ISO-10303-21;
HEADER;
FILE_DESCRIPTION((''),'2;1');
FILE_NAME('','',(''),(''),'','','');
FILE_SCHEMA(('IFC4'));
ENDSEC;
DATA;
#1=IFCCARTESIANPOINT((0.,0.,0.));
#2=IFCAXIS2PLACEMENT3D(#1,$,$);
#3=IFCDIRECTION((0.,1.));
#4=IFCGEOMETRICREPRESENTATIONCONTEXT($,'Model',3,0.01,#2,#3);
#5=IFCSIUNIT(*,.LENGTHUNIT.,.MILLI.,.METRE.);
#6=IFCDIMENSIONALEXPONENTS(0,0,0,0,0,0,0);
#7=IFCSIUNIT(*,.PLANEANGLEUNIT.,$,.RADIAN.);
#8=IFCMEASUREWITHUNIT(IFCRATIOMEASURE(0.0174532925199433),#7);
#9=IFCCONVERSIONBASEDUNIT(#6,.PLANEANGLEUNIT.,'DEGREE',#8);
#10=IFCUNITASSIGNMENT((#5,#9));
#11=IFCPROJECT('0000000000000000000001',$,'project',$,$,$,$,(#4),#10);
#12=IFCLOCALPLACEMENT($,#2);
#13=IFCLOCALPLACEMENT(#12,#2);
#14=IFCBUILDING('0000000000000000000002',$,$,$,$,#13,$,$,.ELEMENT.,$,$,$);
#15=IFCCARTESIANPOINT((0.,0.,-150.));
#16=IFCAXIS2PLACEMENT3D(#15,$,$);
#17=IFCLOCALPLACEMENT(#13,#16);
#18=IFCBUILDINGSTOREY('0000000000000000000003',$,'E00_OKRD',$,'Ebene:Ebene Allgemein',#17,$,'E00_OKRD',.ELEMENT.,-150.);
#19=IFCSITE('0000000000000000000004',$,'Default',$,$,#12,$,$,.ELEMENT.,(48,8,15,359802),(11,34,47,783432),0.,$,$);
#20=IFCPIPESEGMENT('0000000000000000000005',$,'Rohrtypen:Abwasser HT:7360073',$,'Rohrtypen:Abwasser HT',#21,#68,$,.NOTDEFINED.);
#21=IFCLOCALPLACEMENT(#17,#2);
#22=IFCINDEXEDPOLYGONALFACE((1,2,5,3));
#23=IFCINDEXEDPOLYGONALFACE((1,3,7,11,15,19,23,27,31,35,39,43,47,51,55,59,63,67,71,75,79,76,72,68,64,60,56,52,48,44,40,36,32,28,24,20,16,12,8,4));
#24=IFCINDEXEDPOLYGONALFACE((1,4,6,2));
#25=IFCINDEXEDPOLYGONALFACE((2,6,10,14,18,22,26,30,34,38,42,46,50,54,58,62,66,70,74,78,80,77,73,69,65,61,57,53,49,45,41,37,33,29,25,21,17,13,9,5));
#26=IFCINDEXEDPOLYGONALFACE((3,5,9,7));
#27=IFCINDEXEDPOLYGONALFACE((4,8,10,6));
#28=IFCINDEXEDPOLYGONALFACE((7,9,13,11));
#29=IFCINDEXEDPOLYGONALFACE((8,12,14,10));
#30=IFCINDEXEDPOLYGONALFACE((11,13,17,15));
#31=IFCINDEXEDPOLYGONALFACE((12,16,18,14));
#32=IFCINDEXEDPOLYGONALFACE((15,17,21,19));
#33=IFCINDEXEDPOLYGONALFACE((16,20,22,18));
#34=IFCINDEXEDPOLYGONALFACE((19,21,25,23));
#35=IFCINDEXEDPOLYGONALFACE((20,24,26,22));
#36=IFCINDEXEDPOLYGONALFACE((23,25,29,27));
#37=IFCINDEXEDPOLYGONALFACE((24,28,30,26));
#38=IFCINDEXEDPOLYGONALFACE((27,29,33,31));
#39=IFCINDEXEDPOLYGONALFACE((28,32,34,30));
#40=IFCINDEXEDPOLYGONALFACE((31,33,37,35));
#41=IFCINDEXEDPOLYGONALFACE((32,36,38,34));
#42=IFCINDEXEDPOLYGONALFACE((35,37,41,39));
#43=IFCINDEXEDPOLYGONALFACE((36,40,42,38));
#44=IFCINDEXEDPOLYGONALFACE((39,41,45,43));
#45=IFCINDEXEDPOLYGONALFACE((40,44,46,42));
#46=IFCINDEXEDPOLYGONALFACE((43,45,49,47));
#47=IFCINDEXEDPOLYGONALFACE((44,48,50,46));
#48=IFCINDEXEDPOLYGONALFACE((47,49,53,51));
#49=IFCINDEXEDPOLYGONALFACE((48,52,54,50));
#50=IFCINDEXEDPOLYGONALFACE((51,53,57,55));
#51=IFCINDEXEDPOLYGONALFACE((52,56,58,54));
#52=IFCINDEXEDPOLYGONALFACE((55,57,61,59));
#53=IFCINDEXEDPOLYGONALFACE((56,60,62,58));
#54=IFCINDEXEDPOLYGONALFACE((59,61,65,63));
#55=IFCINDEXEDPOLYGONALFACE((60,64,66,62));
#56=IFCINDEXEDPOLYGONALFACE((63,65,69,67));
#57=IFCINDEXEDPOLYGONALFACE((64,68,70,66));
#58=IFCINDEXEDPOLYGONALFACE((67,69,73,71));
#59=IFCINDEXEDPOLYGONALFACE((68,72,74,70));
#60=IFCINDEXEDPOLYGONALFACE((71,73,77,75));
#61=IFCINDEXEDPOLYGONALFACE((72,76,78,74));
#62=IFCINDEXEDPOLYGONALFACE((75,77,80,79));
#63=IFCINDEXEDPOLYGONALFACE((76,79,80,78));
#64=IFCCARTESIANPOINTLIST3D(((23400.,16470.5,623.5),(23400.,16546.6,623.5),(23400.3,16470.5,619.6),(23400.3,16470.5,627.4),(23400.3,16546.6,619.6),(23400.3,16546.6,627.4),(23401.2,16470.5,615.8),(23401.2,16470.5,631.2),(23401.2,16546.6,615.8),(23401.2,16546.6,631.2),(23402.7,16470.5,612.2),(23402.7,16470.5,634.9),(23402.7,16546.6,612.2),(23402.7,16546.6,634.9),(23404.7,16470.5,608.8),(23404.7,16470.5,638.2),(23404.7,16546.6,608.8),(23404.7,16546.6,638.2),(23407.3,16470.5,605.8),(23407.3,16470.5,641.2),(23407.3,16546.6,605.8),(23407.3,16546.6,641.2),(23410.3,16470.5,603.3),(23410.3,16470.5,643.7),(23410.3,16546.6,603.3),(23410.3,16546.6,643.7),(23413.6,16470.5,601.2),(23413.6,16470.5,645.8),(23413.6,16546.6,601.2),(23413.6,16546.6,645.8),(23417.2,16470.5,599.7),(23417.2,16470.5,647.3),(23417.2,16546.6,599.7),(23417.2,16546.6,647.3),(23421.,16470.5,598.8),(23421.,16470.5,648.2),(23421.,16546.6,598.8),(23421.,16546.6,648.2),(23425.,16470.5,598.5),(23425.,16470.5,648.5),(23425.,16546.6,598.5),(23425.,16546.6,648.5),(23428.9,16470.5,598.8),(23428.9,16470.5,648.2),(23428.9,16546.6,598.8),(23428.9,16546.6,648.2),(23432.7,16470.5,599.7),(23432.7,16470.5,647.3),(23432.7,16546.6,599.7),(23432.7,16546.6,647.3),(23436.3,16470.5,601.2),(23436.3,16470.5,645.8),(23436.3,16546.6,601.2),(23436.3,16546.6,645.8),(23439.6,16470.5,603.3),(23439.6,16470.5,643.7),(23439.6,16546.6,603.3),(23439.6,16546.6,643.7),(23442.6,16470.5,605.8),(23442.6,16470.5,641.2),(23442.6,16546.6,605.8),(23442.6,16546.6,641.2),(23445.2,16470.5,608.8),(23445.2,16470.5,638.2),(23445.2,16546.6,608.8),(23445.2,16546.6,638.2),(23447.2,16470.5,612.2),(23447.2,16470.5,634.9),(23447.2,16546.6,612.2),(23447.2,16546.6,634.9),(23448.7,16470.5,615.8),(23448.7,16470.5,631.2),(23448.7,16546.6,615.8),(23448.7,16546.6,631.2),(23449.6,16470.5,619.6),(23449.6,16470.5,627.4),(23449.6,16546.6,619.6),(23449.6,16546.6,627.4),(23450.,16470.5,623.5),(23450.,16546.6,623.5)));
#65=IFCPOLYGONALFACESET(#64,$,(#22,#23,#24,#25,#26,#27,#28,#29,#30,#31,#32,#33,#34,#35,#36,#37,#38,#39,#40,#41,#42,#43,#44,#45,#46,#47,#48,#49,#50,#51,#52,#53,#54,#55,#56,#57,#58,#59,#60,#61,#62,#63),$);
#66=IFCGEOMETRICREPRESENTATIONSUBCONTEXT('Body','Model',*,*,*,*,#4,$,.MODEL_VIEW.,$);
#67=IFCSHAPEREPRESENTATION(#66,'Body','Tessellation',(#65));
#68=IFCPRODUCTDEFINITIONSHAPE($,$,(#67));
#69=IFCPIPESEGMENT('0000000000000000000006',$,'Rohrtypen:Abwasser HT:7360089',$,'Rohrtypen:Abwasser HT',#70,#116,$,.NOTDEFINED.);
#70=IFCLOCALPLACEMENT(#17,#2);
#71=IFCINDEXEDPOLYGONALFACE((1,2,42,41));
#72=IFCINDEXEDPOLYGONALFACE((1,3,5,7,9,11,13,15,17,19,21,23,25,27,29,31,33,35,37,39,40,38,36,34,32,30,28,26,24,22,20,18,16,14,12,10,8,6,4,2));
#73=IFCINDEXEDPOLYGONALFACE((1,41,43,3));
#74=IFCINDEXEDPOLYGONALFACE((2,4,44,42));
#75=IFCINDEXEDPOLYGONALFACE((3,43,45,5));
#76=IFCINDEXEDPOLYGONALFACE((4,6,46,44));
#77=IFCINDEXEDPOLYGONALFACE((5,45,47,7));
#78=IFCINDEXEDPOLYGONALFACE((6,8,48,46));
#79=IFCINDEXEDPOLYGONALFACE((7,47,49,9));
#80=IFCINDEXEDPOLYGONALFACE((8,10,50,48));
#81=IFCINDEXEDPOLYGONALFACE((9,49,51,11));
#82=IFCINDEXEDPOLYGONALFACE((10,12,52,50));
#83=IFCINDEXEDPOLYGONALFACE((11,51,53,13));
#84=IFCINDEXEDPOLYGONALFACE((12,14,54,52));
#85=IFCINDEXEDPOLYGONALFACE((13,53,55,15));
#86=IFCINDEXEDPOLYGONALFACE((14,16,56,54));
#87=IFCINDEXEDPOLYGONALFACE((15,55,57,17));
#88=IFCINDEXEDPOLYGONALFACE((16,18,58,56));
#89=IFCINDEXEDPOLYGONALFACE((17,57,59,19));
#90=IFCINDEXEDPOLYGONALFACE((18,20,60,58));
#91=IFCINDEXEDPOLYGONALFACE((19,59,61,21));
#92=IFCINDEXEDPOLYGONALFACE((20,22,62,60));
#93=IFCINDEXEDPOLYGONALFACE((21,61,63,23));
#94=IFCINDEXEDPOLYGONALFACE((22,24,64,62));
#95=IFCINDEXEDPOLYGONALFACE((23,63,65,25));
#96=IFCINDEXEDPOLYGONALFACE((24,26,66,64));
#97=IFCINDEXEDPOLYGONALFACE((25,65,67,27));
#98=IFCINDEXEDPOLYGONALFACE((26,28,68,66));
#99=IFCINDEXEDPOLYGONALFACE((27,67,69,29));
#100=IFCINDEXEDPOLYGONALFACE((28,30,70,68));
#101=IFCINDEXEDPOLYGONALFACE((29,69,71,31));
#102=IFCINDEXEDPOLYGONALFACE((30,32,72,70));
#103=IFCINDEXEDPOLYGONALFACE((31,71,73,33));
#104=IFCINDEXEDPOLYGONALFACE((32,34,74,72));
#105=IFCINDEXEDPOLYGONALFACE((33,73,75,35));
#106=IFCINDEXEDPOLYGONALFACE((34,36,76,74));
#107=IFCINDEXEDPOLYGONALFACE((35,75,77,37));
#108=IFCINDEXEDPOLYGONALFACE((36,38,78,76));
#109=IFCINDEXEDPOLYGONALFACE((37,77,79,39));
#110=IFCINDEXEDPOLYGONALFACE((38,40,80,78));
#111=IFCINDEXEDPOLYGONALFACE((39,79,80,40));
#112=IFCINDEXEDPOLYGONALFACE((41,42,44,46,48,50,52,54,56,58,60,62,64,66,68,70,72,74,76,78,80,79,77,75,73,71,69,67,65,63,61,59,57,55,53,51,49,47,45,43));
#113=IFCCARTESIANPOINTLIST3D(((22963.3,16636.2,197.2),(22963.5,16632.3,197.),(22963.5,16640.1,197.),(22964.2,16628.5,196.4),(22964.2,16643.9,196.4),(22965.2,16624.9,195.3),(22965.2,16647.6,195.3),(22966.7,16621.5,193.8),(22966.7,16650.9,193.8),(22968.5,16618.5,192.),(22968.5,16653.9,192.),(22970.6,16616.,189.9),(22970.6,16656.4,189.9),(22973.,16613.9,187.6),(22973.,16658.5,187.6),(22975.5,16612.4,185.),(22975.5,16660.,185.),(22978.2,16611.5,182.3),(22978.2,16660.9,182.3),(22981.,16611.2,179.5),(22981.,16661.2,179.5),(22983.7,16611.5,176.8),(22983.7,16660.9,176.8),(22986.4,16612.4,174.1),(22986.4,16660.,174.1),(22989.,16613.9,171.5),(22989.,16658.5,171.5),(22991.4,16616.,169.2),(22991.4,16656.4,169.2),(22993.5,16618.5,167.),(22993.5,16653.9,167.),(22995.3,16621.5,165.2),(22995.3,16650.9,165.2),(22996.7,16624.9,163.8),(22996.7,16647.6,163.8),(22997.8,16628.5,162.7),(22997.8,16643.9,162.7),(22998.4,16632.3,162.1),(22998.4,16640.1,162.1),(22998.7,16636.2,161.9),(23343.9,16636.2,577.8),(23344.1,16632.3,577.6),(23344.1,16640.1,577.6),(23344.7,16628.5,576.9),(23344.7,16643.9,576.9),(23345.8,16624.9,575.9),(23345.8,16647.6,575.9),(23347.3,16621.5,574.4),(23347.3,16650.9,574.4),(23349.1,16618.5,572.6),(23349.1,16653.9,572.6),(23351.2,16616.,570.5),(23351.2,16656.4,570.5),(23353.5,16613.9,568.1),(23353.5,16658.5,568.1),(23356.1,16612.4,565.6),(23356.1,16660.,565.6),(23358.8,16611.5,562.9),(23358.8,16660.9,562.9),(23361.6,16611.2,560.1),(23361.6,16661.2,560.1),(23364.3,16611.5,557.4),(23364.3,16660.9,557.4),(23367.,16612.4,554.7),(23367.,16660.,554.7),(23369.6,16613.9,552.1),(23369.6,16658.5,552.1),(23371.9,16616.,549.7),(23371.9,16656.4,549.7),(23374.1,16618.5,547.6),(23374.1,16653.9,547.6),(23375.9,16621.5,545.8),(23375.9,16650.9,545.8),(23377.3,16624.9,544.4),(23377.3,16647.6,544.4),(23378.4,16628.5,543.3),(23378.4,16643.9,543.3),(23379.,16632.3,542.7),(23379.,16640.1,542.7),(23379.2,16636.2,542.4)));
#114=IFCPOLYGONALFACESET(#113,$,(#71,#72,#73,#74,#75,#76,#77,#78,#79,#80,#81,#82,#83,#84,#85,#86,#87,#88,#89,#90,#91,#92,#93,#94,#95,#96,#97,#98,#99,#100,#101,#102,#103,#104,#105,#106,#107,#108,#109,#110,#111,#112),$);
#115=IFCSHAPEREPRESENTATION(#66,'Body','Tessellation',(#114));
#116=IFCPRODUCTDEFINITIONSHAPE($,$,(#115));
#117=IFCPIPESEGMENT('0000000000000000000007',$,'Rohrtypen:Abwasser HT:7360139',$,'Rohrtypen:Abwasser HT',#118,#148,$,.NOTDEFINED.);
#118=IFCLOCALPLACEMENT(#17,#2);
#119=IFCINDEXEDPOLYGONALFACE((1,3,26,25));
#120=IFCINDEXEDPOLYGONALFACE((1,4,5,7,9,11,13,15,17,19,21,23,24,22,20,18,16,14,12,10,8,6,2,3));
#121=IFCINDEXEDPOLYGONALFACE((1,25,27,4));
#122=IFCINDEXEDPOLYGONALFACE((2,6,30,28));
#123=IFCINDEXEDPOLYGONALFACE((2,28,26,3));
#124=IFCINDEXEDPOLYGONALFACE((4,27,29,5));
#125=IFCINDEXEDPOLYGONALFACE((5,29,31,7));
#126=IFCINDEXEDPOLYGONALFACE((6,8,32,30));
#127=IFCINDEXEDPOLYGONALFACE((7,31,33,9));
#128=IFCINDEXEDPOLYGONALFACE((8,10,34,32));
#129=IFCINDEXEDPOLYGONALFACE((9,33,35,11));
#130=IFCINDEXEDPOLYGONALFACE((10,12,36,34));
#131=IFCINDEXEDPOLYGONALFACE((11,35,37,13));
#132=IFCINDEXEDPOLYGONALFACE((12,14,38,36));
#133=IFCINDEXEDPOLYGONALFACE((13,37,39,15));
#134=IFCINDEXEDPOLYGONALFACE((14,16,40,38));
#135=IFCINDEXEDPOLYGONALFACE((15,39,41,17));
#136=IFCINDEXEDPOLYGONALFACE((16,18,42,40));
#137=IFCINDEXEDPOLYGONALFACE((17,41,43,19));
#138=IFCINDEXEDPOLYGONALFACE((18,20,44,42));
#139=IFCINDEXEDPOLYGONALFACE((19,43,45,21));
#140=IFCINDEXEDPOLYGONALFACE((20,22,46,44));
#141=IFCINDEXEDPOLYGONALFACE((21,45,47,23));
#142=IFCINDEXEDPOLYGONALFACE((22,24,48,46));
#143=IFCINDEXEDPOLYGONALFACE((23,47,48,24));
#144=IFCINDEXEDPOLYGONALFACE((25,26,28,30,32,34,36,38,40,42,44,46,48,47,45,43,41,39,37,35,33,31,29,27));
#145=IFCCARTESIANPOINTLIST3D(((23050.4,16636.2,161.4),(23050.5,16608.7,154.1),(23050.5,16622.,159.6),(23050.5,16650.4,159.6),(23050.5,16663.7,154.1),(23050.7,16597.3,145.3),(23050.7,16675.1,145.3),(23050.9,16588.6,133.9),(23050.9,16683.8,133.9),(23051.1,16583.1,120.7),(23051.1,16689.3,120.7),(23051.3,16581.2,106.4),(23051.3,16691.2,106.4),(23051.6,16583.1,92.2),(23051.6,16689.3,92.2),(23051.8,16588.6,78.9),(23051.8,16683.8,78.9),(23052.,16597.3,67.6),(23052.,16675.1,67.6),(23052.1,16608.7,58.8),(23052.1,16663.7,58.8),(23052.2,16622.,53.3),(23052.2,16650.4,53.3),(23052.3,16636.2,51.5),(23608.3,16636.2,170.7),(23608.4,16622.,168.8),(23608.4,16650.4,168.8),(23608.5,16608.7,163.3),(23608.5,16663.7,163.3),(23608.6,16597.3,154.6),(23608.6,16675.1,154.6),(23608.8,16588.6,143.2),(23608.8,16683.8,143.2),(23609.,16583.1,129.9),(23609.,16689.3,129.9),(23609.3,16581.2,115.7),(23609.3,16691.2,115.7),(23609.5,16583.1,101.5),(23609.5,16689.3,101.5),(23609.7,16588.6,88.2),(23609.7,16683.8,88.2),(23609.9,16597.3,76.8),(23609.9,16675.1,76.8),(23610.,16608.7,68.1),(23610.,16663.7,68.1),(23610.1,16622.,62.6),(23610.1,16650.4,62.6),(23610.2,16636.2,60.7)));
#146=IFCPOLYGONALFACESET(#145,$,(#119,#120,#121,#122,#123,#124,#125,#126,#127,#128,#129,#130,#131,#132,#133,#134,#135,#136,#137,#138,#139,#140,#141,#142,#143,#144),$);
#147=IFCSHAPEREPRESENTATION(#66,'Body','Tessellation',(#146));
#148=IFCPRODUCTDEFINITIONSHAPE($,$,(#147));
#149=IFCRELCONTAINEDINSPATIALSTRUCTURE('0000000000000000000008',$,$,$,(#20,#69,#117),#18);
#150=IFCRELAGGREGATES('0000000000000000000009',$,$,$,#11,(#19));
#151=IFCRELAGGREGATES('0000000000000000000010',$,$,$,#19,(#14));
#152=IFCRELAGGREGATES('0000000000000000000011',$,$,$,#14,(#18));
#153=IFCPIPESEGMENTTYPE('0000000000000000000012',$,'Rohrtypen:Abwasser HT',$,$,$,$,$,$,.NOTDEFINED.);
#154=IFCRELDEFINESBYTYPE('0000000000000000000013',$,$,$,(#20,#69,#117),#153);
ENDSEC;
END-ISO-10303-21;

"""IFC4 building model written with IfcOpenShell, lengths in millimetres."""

from ifc_helpers import new_model, entity, si_unit, converted_unit, direction, frame, origin, place, context, subcontext, project, spatial, indexed_curve, outline, extrude, type_object, element, save


model = new_model("IFC4")

# Units and contexts
model_context = context("Model", 3, precision=0.01, world=origin(), true_north=direction((0.0, 1.0)))
body_context = subcontext(model_context, "Body", "Model", "MODEL_VIEW")
ifc_project = project(units=[si_unit("LENGTHUNIT", "METRE", prefix="MILLI"), converted_unit("PLANEANGLEUNIT", "DEGREE", entity("IfcRatioMeasure", 0.0174532925199433), si_unit("PLANEANGLEUNIT", "RADIAN"), dimensions=[0, 0, 0, 0, 0, 0, 0])], contexts=[model_context])

# Site, building, storey
site_placement = place(None, origin())
site = spatial("IfcSite", under=ifc_project, at=site_placement, Name="Default", CompositionType="ELEMENT", RefLatitude=(48, 8, 15, 359802), RefLongitude=(11, 34, 47, 783432), RefElevation=0.0)
building_placement = place(site_placement, origin())
building = spatial("IfcBuilding", under=site, at=building_placement, CompositionType="ELEMENT")
storey_placement = place(building_placement, frame((0.0, 0.0, -150.0)))
storey = spatial("IfcBuildingStorey", under=building, at=storey_placement, Name="E00_OKRD", ObjectType="Ebene:Ebene Allgemein", LongName="E00_OKRD", CompositionType="ELEMENT", Elevation=-150.0)

# Pipe segments
pipe_segment_type_1 = type_object("IfcPipeSegmentType", Name="Rohrtypen:Abwasser HT", PredefinedType="NOTDEFINED")
pipe_segment_1_placement = place(storey_placement, origin())
element("IfcPipeSegment", 1, at=pipe_segment_1_placement, inside=storey, type_object=pipe_segment_type_1, Name="Rohrtypen:Abwasser HT:7360073", ObjectType="Rohrtypen:Abwasser HT", PredefinedType="NOTDEFINED", context=body_context, shape_type="SweptSolid", body=[
    extrude(outline(indexed_curve([(25.0, 0.0), (24.7, 3.9), (23.8, 7.7), (22.3, 11.3), (20.2, 14.7), (17.7, 17.7), (14.7, 20.2), (11.3, 22.3), (7.7, 23.8), (3.9, 24.7), (0.0, 25.0), (-3.9, 24.7), (-7.7, 23.8), (-11.3, 22.3), (-14.7, 20.2), (-17.7, 17.7), (-20.2, 14.7), (-22.3, 11.3), (-23.8, 7.7), (-24.7, 3.9), (-25.0, 0.0), (-24.7, -3.9), (-23.8, -7.7), (-22.3, -11.3), (-20.2, -14.7), (-17.7, -17.7), (-14.7, -20.2), (-11.3, -22.3), (-7.7, -23.8), (-3.9, -24.7), (0.0, -25.0), (3.9, -24.7), (7.7, -23.8), (11.3, -22.3), (14.7, -20.2), (17.7, -17.7), (20.2, -14.7), (22.3, -11.3), (23.8, -7.7), (24.7, -3.9), (25.0, 0.0)], self_intersect=False)), frame((23425.0, 16470.5, 623.5), z_axis=(0.0, 1.0, 0.0), x_axis=(1.0, 0.0, 0.0)), (0.0, 0.0, 1.0), 76.0),
])
pipe_segment_2_placement = place(storey_placement, origin())
element("IfcPipeSegment", 2, at=pipe_segment_2_placement, inside=storey, type_object=pipe_segment_type_1, Name="Rohrtypen:Abwasser HT:7360089", ObjectType="Rohrtypen:Abwasser HT", PredefinedType="NOTDEFINED", context=body_context, shape_type="SweptSolid", body=[
    extrude(outline(indexed_curve([(25.0, 0.0), (24.7, 3.9), (23.8, 7.7), (22.3, 11.3), (20.2, 14.7), (17.7, 17.7), (14.7, 20.2), (11.3, 22.3), (7.7, 23.8), (3.9, 24.7), (0.0, 25.0), (-3.9, 24.7), (-7.7, 23.8), (-11.3, 22.3), (-14.7, 20.2), (-17.7, 17.7), (-20.2, 14.7), (-22.3, 11.3), (-23.8, 7.7), (-24.7, 3.9), (-25.0, 0.0), (-24.7, -3.9), (-23.8, -7.7), (-22.3, -11.3), (-20.2, -14.7), (-17.7, -17.7), (-14.7, -20.2), (-11.3, -22.3), (-7.7, -23.8), (-3.9, -24.7), (0.0, -25.0), (3.9, -24.7), (7.7, -23.8), (11.3, -22.3), (14.7, -20.2), (17.7, -17.7), (20.2, -14.7), (22.3, -11.3), (23.8, -7.7), (24.7, -3.9), (25.0, 0.0)], self_intersect=False)), frame((22981.0, 16636.2, 179.5), z_axis=(0.707107, 0.0, 0.707107), x_axis=(0.0, 1.0, 0.0)), (0.0, 0.0, 1.0), 538.2),
])
pipe_segment_3_placement = place(storey_placement, origin())
element("IfcPipeSegment", 3, at=pipe_segment_3_placement, inside=storey, type_object=pipe_segment_type_1, Name="Rohrtypen:Abwasser HT:7360139", ObjectType="Rohrtypen:Abwasser HT", PredefinedType="NOTDEFINED", context=body_context, shape_type="SweptSolid", body=[
    extrude(outline(indexed_curve([(-7.2, -54.5), (7.2, -54.5), (21.0, -50.8), (33.5, -43.6), (43.6, -33.5), (50.8, -21.0), (54.5, -7.2), (54.5, 7.2), (50.8, 21.0), (43.6, 33.5), (33.5, 43.6), (21.0, 50.8), (7.2, 54.5), (-7.2, 54.5), (-21.0, 50.8), (-33.5, 43.6), (-43.6, 33.5), (-50.8, 21.0), (-54.5, 7.2), (-54.5, -7.2), (-50.8, -21.0), (-43.6, -33.5), (-33.5, -43.6), (-21.0, -50.8), (-7.2, -54.5)], self_intersect=False)), frame((23051.3, 16636.2, 106.4), z_axis=(0.999862, 0.0, 0.016604), x_axis=(-0.016462, -0.130526, 0.991308)), (0.0, 0.0, 1.0), 558.0),
])

save(model, "model.ifc")
